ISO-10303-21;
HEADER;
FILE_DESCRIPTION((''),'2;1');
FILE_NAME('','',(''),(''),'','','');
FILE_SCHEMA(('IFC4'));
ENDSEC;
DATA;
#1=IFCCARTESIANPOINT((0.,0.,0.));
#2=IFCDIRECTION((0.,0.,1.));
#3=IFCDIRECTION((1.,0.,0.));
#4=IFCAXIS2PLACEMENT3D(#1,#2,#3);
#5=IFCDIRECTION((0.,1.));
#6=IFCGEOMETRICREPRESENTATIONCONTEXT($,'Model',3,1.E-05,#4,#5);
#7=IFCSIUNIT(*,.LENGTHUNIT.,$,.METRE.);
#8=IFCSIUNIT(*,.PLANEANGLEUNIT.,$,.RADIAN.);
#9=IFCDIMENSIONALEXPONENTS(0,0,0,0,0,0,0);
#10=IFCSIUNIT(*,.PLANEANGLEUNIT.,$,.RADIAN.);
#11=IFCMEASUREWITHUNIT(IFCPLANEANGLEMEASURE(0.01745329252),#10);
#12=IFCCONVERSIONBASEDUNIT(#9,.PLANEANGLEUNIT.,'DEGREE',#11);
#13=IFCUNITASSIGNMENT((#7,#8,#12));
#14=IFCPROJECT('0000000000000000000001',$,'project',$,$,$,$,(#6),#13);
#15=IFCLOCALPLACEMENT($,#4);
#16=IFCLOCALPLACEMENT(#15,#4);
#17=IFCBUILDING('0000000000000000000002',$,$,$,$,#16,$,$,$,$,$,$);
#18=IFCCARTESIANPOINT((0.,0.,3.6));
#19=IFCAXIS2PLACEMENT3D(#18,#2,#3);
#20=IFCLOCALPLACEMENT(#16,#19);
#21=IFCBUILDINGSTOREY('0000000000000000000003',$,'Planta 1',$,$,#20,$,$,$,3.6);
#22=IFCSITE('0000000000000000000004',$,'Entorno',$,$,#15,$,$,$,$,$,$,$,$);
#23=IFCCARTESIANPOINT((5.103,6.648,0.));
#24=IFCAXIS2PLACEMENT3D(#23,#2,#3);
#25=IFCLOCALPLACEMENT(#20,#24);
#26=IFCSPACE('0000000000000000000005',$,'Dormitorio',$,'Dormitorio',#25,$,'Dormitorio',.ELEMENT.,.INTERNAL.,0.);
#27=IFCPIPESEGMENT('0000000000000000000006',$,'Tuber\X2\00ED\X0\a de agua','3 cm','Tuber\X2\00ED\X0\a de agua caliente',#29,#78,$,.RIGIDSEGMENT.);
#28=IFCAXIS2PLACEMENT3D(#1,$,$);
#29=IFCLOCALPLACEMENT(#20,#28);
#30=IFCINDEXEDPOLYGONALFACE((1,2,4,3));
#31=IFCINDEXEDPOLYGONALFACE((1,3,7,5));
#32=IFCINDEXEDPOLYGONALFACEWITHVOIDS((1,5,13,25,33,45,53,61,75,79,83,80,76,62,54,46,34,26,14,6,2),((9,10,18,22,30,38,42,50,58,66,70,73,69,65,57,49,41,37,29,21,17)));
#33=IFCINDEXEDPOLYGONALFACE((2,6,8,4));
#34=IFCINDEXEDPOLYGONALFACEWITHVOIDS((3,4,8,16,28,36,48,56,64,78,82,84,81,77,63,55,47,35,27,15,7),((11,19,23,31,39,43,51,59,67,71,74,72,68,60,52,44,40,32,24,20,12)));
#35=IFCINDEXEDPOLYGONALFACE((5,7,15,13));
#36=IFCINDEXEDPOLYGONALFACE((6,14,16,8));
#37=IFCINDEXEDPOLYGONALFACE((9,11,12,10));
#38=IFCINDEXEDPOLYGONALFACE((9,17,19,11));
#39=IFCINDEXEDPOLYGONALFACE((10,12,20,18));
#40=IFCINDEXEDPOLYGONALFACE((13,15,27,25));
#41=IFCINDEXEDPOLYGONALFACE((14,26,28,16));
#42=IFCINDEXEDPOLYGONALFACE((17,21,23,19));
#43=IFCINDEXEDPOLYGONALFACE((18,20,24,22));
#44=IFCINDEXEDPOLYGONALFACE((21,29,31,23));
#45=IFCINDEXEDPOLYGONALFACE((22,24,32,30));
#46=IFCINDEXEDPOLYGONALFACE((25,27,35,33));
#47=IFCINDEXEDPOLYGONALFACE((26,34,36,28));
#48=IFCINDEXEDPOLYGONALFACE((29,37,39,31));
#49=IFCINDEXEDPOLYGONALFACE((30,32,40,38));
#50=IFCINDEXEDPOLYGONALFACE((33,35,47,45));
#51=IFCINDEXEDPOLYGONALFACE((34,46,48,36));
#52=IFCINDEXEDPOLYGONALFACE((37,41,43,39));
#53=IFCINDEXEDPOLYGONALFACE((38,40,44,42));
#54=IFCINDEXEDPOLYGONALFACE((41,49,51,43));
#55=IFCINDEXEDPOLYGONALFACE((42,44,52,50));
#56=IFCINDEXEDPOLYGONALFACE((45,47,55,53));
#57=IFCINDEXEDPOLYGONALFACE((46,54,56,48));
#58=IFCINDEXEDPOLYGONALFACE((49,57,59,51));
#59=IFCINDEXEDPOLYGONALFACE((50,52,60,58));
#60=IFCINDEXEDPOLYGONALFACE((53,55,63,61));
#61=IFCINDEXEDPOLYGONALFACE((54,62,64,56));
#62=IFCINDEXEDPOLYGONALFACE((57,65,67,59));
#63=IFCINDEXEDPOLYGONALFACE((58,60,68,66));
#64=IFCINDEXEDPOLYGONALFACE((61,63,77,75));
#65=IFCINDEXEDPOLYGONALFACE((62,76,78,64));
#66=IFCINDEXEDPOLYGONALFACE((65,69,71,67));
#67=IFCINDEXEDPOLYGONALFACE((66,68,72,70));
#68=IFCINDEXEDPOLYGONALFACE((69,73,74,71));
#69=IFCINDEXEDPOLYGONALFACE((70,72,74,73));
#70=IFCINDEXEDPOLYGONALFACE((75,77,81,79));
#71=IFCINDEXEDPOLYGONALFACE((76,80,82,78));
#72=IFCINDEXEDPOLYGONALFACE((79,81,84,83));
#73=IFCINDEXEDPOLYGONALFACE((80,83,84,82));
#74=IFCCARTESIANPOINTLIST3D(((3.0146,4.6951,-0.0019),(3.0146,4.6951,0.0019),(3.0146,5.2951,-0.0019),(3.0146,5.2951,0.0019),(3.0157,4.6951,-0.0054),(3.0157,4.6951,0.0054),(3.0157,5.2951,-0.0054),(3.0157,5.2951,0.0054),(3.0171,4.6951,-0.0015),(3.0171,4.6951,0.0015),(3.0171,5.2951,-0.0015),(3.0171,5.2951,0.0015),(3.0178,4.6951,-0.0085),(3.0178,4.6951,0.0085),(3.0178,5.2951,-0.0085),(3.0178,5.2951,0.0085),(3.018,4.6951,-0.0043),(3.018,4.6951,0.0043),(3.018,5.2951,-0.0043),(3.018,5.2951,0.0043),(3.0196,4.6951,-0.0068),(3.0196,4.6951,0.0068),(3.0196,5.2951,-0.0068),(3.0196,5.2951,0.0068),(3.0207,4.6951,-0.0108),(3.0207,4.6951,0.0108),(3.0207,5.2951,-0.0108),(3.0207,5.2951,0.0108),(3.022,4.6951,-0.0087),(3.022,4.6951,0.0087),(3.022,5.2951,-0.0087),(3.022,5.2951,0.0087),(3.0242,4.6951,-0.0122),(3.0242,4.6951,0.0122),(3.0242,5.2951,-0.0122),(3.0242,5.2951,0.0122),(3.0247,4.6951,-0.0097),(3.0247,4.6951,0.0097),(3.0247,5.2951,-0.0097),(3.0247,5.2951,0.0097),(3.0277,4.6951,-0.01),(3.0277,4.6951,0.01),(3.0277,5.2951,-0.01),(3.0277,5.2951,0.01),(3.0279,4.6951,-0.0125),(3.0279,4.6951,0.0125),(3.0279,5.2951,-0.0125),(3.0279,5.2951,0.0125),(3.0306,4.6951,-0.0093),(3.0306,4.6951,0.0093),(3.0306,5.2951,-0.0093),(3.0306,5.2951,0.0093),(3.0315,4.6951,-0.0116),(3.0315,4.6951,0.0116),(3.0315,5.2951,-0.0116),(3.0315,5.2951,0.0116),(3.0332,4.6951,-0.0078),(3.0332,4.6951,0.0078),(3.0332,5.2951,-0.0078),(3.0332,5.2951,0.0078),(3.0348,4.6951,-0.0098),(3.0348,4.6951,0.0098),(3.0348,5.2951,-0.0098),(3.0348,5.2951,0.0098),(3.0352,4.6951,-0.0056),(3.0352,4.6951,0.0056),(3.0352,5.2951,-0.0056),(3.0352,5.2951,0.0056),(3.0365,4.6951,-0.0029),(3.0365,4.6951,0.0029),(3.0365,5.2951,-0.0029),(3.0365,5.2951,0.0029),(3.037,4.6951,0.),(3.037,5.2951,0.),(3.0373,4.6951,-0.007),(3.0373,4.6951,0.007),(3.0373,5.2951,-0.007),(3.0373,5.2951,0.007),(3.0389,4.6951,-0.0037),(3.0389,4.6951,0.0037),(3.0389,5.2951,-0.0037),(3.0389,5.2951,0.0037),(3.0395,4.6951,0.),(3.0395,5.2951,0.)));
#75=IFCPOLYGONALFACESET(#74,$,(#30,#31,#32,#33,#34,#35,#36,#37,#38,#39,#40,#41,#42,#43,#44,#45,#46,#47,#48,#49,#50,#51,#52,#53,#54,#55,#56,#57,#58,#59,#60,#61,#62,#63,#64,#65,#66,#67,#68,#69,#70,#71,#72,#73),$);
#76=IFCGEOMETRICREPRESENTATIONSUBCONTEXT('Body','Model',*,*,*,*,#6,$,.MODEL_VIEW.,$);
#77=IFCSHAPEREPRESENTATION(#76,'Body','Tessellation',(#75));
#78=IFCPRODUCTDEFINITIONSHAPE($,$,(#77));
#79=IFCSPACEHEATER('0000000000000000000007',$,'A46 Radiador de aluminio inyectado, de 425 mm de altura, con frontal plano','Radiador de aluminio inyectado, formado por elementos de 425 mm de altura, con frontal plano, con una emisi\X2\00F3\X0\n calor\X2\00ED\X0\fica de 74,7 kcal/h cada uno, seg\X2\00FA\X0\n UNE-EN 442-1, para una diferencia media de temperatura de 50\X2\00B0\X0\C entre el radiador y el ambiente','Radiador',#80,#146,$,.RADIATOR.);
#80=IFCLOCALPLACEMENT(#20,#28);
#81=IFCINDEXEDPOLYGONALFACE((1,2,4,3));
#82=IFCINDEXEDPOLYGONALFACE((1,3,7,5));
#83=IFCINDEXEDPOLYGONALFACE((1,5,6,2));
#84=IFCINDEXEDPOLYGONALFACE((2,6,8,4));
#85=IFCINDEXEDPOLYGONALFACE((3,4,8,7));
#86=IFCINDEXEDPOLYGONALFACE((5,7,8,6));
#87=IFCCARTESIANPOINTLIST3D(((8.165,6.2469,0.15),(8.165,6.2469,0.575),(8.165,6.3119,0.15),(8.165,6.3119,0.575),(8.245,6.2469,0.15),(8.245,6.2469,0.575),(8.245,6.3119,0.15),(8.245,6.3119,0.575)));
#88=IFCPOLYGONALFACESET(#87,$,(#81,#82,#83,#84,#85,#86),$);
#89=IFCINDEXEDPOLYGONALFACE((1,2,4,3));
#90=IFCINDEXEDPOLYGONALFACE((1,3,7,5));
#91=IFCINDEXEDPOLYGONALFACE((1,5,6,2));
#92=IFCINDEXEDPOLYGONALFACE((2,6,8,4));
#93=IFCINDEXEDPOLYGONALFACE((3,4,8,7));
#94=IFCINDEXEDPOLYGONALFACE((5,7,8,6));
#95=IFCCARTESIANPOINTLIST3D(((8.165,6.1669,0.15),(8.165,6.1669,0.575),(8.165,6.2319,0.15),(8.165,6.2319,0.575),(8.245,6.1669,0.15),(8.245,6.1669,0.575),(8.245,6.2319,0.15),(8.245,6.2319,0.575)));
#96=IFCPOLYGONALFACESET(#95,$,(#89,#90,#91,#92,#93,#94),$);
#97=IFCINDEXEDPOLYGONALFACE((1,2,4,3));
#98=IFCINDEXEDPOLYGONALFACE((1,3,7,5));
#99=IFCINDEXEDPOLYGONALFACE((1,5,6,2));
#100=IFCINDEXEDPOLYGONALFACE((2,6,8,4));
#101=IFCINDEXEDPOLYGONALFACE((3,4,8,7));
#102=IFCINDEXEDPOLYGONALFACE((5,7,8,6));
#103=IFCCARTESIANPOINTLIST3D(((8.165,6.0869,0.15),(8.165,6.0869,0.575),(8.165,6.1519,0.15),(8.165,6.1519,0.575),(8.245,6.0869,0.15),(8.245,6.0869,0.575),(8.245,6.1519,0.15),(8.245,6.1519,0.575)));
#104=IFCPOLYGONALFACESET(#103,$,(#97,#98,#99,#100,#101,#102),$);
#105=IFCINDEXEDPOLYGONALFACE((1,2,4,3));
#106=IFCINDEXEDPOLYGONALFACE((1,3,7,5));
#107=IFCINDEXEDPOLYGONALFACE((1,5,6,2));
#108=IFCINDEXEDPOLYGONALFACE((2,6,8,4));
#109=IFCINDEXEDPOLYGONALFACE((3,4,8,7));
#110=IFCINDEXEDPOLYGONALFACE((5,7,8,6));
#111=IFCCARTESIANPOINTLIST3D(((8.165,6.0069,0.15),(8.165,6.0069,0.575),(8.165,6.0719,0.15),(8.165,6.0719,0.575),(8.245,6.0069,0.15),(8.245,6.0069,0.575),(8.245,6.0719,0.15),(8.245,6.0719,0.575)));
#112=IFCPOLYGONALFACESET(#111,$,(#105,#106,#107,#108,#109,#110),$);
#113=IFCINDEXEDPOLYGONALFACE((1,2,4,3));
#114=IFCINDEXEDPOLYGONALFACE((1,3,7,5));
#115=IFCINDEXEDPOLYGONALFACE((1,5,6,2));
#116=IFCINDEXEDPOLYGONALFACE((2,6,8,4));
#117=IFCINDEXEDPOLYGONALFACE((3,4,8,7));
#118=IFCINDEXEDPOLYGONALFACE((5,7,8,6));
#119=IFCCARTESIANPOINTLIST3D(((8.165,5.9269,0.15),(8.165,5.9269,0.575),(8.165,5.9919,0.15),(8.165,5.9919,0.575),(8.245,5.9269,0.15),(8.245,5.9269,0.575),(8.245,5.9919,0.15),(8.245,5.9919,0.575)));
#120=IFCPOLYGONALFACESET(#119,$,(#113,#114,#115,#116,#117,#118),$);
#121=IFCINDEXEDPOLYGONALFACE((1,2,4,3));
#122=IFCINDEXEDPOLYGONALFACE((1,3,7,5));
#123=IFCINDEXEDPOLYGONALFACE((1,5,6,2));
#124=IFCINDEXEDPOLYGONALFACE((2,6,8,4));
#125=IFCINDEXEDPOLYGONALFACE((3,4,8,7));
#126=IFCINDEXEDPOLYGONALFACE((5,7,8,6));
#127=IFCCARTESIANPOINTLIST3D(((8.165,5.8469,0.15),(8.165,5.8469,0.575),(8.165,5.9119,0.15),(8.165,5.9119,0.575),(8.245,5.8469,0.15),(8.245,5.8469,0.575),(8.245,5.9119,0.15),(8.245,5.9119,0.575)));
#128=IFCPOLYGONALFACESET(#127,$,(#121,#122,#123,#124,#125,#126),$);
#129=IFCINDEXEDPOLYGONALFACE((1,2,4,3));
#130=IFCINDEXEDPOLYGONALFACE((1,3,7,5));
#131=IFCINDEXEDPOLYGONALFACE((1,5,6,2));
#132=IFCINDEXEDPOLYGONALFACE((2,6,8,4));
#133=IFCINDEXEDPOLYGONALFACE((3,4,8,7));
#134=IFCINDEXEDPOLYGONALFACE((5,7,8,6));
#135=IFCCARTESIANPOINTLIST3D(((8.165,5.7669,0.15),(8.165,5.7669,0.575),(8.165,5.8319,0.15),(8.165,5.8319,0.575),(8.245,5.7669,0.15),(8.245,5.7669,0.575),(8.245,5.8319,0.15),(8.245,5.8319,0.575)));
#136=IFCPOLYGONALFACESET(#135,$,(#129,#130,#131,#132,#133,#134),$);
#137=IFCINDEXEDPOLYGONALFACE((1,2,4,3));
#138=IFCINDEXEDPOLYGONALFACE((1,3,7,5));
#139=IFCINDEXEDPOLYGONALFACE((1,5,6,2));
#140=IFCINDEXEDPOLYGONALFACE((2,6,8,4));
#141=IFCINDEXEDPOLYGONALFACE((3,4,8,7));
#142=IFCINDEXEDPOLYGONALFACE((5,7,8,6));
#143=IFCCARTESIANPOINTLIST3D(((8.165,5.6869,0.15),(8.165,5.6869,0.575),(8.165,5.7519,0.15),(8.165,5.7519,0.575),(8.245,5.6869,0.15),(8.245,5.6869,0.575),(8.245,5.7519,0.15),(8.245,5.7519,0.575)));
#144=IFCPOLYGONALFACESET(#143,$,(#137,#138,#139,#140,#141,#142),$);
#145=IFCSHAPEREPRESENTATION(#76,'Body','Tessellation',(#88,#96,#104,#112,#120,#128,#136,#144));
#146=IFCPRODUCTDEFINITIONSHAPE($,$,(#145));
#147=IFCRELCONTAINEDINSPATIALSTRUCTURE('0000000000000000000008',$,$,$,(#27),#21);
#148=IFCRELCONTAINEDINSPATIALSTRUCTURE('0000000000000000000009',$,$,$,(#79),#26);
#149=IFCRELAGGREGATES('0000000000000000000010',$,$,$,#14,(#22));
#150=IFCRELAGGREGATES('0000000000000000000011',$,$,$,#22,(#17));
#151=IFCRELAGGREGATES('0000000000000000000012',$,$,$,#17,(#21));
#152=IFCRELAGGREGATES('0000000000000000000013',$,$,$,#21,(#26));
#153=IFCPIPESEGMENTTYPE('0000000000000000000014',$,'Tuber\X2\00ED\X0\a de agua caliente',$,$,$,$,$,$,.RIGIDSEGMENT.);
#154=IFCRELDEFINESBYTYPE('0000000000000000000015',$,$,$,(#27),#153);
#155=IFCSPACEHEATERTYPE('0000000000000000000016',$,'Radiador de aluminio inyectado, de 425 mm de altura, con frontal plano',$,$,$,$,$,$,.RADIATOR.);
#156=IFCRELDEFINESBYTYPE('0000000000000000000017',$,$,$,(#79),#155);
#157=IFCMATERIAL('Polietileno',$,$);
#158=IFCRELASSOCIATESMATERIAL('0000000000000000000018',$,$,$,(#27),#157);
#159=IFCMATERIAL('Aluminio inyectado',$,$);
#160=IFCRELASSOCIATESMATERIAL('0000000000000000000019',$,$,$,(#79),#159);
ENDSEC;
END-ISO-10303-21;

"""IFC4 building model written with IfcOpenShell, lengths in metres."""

from ifc_helpers import new_model, entity, si_unit, converted_unit, direction, frame, origin_with_axes, origin_2d_with_axis, place, context, subcontext, project, spatial, rectangle, hollow_circle, extrude, material, type_object, element, save


model = new_model("IFC4")

# Units and contexts
model_context = context("Model", 3, precision=1e-05, world=origin_with_axes(), true_north=direction((0.0, 1.0)))
body_context = subcontext(model_context, "Body", "Model", "MODEL_VIEW")
ifc_project = project(units=[si_unit("LENGTHUNIT", "METRE"), si_unit("PLANEANGLEUNIT", "RADIAN"), converted_unit("PLANEANGLEUNIT", "DEGREE", entity("IfcPlaneAngleMeasure", 0.01745329252), si_unit("PLANEANGLEUNIT", "RADIAN"), dimensions=[0, 0, 0, 0, 0, 0, 0])], contexts=[model_context])

# Site, building, storey
site_placement = place(None, origin_with_axes())
site = spatial("IfcSite", under=ifc_project, at=site_placement, Name="Entorno")
building_placement = place(site_placement, origin_with_axes())
building = spatial("IfcBuilding", under=site, at=building_placement)
storey_placement = place(building_placement, frame((0.0, 0.0, 3.6), z_axis=(0.0, 0.0, 1.0), x_axis=(1.0, 0.0, 0.0)))
storey = spatial("IfcBuildingStorey", under=building, at=storey_placement, Name="Planta 1", Elevation=3.6)

# Pipe segment
ifc_material_1 = material(Name="Polietileno")
pipe_segment_type_1 = type_object("IfcPipeSegmentType", Name="Tubería de agua caliente", PredefinedType="RIGIDSEGMENT")
pipe_segment_1_placement = place(storey_placement, frame((3.027, 5.2951, 0.0), z_axis=(0.0, -1.0, 0.0), x_axis=(1.0, 0.0, 0.0)))
element("IfcPipeSegment", 1, at=pipe_segment_1_placement, inside=storey, type_object=pipe_segment_type_1, material=ifc_material_1, Name="Tubería de agua", Description="3 cm", ObjectType="Tubería de agua caliente", PredefinedType="RIGIDSEGMENT", context=body_context, shape_type="SweptSolid", body=[
    extrude(hollow_circle(Radius=0.0125, WallThickness=0.0025, at=origin_2d_with_axis()), origin_with_axes(), (0.0, 0.0, 1.0), 0.6),
])

# Shared definitions
space_placement = place(storey_placement, frame((5.103, 6.648, 0.0), z_axis=(0.0, 0.0, 1.0), x_axis=(1.0, 0.0, 0.0)))
space = spatial("IfcSpace", under=storey, at=space_placement, Name="Dormitorio", ObjectType="Dormitorio", LongName="Dormitorio", CompositionType="ELEMENT", PredefinedType="INTERNAL", ElevationWithFlooring=0.0)

# Space heater
ifc_material_2 = material(Name="Aluminio inyectado")
space_heater_type = type_object("IfcSpaceHeaterType", Name="Radiador de aluminio inyectado, de 425 mm de altura, con frontal plano", PredefinedType="RADIATOR")
space_heater_placement = place(space_placement, frame((3.102, -0.6486, 0.15), z_axis=(0.0, 0.0, 1.0), x_axis=(0.0, -1.0, 0.0)))
element("IfcSpaceHeater", 2, at=space_heater_placement, inside=space, type_object=space_heater_type, material=ifc_material_2, Name="A46 Radiador de aluminio inyectado, de 425 mm de altura, con frontal plano", Description="Radiador de aluminio inyectado, formado por elementos de 425 mm de altura, con frontal plano, con una emisión calorífica de 74,7 kcal/h cada uno, según UNE-EN 442-1, para una diferencia media de temperatura de 50°C entre el radiador y el ambiente", ObjectType="Radiador", PredefinedType="RADIATOR", context=body_context, shape_type="SweptSolid", body=[
    extrude(rectangle(XDim=0.065, YDim=0.08, at=origin_2d_with_axis()), frame((-0.28, 0.0, 0.0), z_axis=(0.0, 0.0, 1.0), x_axis=(1.0, 0.0, 0.0)), (0.0, 0.0, 1.0), 0.425),
    extrude(rectangle(XDim=0.065, YDim=0.08, at=origin_2d_with_axis()), frame((-0.2, 0.0, 0.0), z_axis=(0.0, 0.0, 1.0), x_axis=(1.0, 0.0, 0.0)), (0.0, 0.0, 1.0), 0.425),
    extrude(rectangle(XDim=0.065, YDim=0.08, at=origin_2d_with_axis()), frame((-0.12, 0.0, 0.0), z_axis=(0.0, 0.0, 1.0), x_axis=(1.0, 0.0, 0.0)), (0.0, 0.0, 1.0), 0.425),
    extrude(rectangle(XDim=0.065, YDim=0.08, at=origin_2d_with_axis()), frame((-0.04, 0.0, 0.0), z_axis=(0.0, 0.0, 1.0), x_axis=(1.0, 0.0, 0.0)), (0.0, 0.0, 1.0), 0.425),
    extrude(rectangle(XDim=0.065, YDim=0.08, at=origin_2d_with_axis()), frame((0.04, 0.0, 0.0), z_axis=(0.0, 0.0, 1.0), x_axis=(1.0, 0.0, 0.0)), (0.0, 0.0, 1.0), 0.425),
    extrude(rectangle(XDim=0.065, YDim=0.08, at=origin_2d_with_axis()), frame((0.12, 0.0, 0.0), z_axis=(0.0, 0.0, 1.0), x_axis=(1.0, 0.0, 0.0)), (0.0, 0.0, 1.0), 0.425),
    extrude(rectangle(XDim=0.065, YDim=0.08, at=origin_2d_with_axis()), frame((0.2, 0.0, 0.0), z_axis=(0.0, 0.0, 1.0), x_axis=(1.0, 0.0, 0.0)), (0.0, 0.0, 1.0), 0.425),
    extrude(rectangle(XDim=0.065, YDim=0.08, at=origin_2d_with_axis()), frame((0.28, 0.0, 0.0), z_axis=(0.0, 0.0, 1.0), x_axis=(1.0, 0.0, 0.0)), (0.0, 0.0, 1.0), 0.425),
])

save(model, "model.ifc")
